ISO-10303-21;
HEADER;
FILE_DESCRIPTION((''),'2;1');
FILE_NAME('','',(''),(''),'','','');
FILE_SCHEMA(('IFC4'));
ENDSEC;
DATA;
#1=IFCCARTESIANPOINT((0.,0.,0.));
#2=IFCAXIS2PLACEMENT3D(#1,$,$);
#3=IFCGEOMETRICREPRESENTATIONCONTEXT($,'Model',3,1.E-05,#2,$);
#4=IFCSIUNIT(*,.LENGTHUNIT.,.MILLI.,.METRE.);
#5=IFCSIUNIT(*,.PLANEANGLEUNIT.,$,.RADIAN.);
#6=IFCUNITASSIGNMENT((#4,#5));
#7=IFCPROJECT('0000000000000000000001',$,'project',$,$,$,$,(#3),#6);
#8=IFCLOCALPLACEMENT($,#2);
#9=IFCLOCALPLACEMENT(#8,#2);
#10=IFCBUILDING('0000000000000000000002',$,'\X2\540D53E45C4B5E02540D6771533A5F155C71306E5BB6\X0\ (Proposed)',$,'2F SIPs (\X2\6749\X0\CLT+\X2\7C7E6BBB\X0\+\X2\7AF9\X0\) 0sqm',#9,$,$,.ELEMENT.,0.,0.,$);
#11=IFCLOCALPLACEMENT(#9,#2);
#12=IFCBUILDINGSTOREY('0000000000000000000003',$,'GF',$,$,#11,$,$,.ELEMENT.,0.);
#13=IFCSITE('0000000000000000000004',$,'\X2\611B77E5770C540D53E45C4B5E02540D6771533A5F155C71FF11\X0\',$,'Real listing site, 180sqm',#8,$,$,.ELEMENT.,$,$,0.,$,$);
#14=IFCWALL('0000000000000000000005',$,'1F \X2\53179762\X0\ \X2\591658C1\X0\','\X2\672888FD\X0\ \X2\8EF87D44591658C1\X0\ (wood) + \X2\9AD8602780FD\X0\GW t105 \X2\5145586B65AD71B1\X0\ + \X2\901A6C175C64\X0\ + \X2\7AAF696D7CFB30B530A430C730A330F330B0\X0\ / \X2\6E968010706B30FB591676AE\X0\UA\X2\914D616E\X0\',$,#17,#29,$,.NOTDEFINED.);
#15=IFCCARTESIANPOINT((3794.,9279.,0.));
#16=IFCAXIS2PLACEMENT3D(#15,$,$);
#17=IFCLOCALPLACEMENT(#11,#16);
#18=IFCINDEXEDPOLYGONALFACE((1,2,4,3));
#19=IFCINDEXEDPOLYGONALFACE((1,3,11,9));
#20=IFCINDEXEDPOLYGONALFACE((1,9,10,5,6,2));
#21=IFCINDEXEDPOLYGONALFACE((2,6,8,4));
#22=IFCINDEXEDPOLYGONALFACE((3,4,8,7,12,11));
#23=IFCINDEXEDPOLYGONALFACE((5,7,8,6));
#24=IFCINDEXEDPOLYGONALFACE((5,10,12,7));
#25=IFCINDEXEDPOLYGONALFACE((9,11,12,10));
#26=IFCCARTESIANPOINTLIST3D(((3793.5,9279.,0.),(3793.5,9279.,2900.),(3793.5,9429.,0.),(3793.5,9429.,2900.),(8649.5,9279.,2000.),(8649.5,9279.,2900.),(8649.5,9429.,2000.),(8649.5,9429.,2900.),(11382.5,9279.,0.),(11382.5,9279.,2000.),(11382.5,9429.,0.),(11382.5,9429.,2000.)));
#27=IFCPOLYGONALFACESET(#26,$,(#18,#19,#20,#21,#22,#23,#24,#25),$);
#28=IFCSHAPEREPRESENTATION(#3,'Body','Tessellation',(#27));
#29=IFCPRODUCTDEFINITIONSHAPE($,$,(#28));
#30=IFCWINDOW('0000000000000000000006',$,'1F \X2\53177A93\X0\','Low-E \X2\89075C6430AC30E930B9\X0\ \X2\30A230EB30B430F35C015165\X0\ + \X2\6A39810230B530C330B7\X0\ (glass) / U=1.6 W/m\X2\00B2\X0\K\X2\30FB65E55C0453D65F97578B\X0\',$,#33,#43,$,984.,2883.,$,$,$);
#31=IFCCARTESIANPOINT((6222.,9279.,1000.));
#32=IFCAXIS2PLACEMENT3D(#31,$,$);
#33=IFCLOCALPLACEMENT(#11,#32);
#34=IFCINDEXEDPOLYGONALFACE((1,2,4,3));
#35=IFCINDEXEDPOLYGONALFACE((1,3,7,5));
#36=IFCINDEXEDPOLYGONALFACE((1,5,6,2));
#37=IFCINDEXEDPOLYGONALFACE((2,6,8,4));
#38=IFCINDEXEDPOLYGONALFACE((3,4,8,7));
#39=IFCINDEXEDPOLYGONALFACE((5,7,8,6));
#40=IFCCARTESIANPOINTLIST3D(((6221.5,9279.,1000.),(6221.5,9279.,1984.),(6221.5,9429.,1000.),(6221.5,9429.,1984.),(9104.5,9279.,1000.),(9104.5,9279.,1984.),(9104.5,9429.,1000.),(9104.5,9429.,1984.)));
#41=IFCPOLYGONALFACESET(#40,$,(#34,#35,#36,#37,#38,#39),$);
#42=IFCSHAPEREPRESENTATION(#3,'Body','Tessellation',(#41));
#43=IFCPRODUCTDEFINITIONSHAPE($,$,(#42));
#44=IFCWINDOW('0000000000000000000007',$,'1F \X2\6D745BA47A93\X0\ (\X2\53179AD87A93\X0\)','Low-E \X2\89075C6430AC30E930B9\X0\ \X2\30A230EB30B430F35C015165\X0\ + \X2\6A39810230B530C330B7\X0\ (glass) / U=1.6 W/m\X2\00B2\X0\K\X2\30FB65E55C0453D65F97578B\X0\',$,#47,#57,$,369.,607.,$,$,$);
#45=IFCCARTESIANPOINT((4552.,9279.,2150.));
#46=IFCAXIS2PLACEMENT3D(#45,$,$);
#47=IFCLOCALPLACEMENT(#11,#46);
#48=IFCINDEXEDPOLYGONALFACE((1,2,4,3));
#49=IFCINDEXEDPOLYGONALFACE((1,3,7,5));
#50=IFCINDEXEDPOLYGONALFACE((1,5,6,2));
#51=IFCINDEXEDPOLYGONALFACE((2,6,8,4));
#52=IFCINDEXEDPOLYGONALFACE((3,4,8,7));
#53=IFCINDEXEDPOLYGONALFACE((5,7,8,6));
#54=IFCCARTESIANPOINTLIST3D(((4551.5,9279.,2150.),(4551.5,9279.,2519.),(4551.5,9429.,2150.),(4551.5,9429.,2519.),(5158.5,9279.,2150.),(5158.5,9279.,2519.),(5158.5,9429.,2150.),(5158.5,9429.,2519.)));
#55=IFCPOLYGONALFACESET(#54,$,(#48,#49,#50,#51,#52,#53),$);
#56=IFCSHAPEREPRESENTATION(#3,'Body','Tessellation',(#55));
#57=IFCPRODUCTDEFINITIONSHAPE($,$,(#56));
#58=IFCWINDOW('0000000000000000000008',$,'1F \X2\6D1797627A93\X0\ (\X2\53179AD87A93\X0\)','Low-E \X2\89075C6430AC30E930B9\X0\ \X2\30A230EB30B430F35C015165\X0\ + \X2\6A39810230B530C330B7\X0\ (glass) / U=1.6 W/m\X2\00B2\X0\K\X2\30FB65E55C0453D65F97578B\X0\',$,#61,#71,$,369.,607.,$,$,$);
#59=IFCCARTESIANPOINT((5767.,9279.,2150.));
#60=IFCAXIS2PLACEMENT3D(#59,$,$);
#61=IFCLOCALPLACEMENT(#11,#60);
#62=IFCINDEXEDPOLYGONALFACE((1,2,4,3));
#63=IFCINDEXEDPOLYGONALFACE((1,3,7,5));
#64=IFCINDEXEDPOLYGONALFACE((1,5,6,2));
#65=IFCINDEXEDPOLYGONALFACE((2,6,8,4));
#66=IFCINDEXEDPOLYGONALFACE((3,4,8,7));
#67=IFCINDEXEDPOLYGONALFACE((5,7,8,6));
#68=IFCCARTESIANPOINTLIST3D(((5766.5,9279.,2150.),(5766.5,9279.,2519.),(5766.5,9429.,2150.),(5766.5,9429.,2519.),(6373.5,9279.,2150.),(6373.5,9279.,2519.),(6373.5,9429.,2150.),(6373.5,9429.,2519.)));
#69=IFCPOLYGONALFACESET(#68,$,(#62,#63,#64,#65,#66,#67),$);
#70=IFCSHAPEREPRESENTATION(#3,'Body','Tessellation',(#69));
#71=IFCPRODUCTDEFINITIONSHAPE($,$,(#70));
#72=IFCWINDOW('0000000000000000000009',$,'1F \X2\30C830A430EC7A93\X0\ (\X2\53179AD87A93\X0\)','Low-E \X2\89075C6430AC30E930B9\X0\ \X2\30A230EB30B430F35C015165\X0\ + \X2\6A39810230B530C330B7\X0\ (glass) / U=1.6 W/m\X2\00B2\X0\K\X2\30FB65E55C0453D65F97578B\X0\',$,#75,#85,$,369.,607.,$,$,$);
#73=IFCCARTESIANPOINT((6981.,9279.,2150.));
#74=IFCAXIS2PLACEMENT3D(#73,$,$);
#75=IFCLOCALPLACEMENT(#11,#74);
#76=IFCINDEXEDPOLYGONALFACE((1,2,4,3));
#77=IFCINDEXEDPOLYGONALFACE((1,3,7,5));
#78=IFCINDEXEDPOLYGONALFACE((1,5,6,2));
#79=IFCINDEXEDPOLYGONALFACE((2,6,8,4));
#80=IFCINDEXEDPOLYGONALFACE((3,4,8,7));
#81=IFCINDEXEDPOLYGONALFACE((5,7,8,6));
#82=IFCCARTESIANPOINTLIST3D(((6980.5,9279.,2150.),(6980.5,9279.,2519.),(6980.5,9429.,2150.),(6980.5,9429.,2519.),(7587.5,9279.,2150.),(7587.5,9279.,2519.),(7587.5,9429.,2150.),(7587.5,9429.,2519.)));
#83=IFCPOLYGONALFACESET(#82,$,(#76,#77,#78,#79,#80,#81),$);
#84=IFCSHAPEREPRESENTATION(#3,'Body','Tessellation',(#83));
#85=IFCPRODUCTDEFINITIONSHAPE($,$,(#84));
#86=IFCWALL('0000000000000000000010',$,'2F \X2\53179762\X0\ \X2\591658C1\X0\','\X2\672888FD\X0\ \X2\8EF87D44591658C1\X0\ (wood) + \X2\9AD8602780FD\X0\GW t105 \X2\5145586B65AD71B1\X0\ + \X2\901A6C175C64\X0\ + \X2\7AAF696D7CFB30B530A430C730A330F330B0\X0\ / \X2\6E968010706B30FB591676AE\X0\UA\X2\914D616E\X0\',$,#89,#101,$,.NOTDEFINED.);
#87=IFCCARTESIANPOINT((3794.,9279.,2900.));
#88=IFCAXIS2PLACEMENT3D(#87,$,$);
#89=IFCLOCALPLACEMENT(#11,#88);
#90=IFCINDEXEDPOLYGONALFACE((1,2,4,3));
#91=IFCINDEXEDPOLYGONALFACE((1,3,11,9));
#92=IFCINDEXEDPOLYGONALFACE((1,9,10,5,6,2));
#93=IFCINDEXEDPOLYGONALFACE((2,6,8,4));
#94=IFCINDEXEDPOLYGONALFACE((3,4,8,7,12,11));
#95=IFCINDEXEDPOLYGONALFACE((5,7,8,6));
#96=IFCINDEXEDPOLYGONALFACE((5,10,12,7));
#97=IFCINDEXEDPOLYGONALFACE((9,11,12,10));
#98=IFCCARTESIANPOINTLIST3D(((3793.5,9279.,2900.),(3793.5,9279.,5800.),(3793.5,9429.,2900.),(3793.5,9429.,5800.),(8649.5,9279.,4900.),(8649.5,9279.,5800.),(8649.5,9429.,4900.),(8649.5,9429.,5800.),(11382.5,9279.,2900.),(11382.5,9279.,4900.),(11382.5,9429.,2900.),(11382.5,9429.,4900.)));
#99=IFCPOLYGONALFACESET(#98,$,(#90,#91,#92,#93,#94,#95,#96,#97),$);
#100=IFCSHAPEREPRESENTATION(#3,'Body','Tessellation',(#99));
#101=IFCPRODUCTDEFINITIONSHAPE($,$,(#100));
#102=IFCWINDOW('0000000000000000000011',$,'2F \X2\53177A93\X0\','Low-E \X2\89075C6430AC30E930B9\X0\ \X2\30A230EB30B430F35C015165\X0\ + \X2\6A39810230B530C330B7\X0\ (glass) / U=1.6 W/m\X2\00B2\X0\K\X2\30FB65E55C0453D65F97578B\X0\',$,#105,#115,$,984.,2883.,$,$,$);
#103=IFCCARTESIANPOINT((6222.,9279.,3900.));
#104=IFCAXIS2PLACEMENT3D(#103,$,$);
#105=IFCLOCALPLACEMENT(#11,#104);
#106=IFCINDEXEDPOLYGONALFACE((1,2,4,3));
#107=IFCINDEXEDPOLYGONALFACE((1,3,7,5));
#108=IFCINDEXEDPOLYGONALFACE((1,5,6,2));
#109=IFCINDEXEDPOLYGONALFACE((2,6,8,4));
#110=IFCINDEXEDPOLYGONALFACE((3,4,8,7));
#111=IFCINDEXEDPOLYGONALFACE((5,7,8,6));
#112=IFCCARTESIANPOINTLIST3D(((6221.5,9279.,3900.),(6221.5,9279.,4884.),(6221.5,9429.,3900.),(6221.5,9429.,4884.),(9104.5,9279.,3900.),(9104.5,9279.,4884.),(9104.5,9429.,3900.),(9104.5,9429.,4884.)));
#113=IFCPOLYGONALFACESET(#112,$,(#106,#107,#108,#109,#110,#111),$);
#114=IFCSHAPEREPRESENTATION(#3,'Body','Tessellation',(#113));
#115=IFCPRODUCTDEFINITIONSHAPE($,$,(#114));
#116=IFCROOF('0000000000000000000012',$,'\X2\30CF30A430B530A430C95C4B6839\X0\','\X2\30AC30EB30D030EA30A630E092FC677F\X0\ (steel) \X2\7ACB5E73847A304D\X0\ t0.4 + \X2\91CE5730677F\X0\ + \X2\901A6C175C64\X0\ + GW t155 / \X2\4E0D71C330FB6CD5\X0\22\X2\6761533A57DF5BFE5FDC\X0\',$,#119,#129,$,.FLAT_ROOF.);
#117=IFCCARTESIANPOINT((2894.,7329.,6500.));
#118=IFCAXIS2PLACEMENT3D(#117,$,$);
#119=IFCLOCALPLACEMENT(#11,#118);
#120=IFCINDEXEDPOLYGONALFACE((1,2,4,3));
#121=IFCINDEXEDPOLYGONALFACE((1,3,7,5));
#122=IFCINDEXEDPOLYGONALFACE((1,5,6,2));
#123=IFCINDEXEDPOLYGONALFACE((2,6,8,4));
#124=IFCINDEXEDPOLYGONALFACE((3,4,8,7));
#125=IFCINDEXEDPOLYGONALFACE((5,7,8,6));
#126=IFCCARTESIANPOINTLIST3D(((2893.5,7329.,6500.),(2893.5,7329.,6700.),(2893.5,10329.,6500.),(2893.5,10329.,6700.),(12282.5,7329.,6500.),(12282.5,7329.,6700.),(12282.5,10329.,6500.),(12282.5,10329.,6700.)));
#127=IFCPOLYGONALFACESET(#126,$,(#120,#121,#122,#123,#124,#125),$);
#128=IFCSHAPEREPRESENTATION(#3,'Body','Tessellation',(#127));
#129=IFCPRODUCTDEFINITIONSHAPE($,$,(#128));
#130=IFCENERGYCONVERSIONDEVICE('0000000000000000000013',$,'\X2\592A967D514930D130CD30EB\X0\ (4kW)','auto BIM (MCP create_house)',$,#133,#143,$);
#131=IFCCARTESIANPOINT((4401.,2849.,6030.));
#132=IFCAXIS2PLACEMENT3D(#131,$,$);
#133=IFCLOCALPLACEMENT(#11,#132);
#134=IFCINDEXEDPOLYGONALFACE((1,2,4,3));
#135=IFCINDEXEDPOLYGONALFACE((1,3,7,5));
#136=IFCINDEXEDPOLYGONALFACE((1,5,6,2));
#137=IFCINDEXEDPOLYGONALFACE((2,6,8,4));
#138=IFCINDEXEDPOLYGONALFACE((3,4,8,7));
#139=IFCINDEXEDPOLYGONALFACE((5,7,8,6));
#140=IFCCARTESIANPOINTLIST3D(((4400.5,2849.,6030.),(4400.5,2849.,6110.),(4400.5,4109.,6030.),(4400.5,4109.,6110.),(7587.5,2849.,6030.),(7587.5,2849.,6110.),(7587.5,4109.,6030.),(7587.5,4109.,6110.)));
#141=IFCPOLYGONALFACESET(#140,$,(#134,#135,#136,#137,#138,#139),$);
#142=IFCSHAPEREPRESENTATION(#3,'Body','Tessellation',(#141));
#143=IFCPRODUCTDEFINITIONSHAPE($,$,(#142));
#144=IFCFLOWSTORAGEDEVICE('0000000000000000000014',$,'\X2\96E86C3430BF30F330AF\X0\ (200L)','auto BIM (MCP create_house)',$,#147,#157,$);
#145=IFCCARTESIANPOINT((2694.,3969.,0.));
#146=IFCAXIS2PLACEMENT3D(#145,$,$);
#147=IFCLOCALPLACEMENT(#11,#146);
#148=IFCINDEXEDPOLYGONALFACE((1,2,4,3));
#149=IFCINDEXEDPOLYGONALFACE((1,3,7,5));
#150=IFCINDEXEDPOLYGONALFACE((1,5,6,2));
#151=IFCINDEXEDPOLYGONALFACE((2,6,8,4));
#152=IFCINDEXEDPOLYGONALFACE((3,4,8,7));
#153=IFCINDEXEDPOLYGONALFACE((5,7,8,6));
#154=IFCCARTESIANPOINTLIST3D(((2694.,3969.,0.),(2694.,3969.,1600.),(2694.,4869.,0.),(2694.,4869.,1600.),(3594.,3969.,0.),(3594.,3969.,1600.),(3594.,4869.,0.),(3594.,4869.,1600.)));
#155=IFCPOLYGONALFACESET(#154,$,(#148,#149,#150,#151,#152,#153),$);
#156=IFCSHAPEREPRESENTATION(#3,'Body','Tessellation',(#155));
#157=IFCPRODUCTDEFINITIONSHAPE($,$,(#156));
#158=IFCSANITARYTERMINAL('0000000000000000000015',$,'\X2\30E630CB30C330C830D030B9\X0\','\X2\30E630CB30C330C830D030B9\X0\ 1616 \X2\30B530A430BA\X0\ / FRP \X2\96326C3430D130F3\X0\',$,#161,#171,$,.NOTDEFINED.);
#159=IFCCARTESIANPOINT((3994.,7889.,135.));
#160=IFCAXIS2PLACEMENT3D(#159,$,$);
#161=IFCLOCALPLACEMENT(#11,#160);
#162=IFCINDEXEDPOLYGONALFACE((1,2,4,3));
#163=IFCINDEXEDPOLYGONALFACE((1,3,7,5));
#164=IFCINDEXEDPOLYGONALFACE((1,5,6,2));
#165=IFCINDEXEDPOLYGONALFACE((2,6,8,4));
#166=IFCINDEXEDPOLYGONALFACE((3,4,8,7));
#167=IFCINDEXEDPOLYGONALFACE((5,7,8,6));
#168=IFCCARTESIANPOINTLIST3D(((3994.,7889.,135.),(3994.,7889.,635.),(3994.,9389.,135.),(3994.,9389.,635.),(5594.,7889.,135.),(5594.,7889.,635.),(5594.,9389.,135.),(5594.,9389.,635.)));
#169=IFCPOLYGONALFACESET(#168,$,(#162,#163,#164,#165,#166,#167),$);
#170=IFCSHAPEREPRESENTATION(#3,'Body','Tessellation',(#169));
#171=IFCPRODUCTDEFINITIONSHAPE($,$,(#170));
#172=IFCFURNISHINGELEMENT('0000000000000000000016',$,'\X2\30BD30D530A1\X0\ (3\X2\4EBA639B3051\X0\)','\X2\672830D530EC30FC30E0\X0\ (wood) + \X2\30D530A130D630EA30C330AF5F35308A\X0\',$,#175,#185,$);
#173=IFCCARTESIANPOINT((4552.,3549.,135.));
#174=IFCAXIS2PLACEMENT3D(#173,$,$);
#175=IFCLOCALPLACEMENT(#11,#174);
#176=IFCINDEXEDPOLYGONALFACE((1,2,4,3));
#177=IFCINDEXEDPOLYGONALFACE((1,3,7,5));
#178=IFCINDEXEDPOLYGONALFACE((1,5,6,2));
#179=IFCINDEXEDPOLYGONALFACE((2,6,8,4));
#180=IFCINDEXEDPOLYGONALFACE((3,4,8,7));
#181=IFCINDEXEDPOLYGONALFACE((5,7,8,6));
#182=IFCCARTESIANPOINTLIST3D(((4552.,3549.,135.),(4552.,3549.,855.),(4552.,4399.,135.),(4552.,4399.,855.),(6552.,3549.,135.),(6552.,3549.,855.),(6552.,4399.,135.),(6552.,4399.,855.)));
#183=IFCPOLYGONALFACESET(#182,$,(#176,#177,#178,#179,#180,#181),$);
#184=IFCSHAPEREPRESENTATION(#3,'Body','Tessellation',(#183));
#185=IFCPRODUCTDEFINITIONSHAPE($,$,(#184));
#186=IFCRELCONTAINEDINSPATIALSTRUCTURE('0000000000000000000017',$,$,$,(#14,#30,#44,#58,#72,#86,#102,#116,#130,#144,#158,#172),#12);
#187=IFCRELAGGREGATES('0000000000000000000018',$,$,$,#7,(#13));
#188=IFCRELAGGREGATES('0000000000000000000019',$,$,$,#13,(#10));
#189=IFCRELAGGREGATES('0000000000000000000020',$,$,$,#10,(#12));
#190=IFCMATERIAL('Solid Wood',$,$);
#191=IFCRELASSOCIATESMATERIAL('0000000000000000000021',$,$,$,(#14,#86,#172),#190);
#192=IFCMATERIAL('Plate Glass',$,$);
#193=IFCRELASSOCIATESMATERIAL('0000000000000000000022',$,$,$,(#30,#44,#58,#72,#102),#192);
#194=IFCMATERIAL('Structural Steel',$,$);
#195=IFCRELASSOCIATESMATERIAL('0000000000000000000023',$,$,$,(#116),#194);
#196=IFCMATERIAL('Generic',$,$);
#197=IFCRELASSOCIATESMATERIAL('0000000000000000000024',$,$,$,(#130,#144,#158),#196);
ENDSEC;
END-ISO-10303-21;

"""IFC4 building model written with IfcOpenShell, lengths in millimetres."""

from ifc_helpers import new_model, si_unit, frame, frame_2d, origin, place, context, project, spatial, rectangle, extrude, material, element, fill, save


model = new_model("IFC4")

# Units and contexts
model_context = context("Model", 3, precision=1e-05, world=origin())
ifc_project = project(units=[si_unit("LENGTHUNIT", "METRE", prefix="MILLI"), si_unit("PLANEANGLEUNIT", "RADIAN")], contexts=[model_context])

# Site, building, storey
site_placement = place(None, origin())
site = spatial("IfcSite", under=ifc_project, at=site_placement, Name="愛知県名古屋市名東区引山１", ObjectType="Real listing site, 180sqm", CompositionType="ELEMENT", RefElevation=0.0)
building_placement = place(site_placement, origin())
building = spatial("IfcBuilding", under=site, at=building_placement, Name="名古屋市名東区引山の家 (Proposed)", ObjectType="2F SIPs (杉CLT+籾殻+竹) 0sqm", CompositionType="ELEMENT", ElevationOfRefHeight=0.0, ElevationOfTerrain=0.0)
storey_placement = place(building_placement, origin())
storey = spatial("IfcBuildingStorey", under=building, at=storey_placement, Name="GF", CompositionType="ELEMENT", Elevation=0.0)

# Wall, openings, windows
ifc_material_1 = material(Name="Solid Wood")
wall_1_placement = place(storey_placement, frame((3794.0, 9279.0, 0.0)))
wall_1 = element("IfcWall", 1, at=wall_1_placement, inside=storey, material=ifc_material_1, Name="1F 北面 外壁", Description="木製 軸組外壁 (wood) + 高性能GW t105 充填断熱 + 通気層 + 窯業系サイディング / 準耐火・外皮UA配慮", PredefinedType="NOTDEFINED", context=model_context, shape_type="SweptSolid", body=[
    extrude(rectangle(XDim=7589.0, YDim=150.0, at=frame_2d((3794.0, 75.0))), frame((3794.0, 9279.0, 0.0)), (0.0, 0.0, 1.0), 2900.0),
])
opening_1_placement = place(storey_placement, frame((6222.0, 9279.0, 1000.0)))
opening_1 = element("IfcOpeningElement", 2, at=opening_1_placement, cuts=wall_1, PredefinedType="NOTDEFINED", context=model_context, shape_type="SweptSolid", body=[
    extrude(rectangle(XDim=2883.0, YDim=150.0, at=frame_2d((1441.0, 75.0))), frame((6222.0, 9279.0, 1000.0)), (0.0, 0.0, 1.0), 984.0),
])
opening_2_placement = place(storey_placement, frame((4552.0, 9279.0, 2150.0)))
opening_2 = element("IfcOpeningElement", 3, at=opening_2_placement, cuts=wall_1, PredefinedType="NOTDEFINED", context=model_context, shape_type="SweptSolid", body=[
    extrude(rectangle(XDim=607.0, YDim=150.0, at=frame_2d((303.0, 75.0))), frame((4552.0, 9279.0, 2150.0)), (0.0, 0.0, 1.0), 369.0),
])
opening_3_placement = place(storey_placement, frame((5767.0, 9279.0, 2150.0)))
opening_3 = element("IfcOpeningElement", 4, at=opening_3_placement, cuts=wall_1, PredefinedType="NOTDEFINED", context=model_context, shape_type="SweptSolid", body=[
    extrude(rectangle(XDim=607.0, YDim=150.0, at=frame_2d((303.0, 75.0))), frame((5767.0, 9279.0, 2150.0)), (0.0, 0.0, 1.0), 369.0),
])
opening_4_placement = place(storey_placement, frame((6981.0, 9279.0, 2150.0)))
opening_4 = element("IfcOpeningElement", 5, at=opening_4_placement, cuts=wall_1, PredefinedType="NOTDEFINED", context=model_context, shape_type="SweptSolid", body=[
    extrude(rectangle(XDim=607.0, YDim=150.0, at=frame_2d((303.0, 75.0))), frame((6981.0, 9279.0, 2150.0)), (0.0, 0.0, 1.0), 369.0),
])
ifc_material_2 = material(Name="Plate Glass")
window_1_placement = place(storey_placement, frame((6222.0, 9279.0, 1000.0)))
window_1 = element("IfcWindow", 6, at=window_1_placement, inside=storey, material=ifc_material_2, Name="1F 北窓", Description="Low-E 複層ガラス アルゴン封入 + 樹脂サッシ (glass) / U=1.6 W/m²K・日射取得型", OverallHeight=984.0, OverallWidth=2883.0, context=model_context, shape_type="SweptSolid", body=[
    extrude(rectangle(XDim=2883.0, YDim=150.0, at=frame_2d((1441.0, 75.0))), frame((6222.0, 9279.0, 1000.0)), (0.0, 0.0, 1.0), 984.0),
])
fill(opening_1, window_1)
window_2_placement = place(storey_placement, frame((4552.0, 9279.0, 2150.0)))
window_2 = element("IfcWindow", 7, at=window_2_placement, inside=storey, material=ifc_material_2, Name="1F 浴室窓 (北高窓)", Description="Low-E 複層ガラス アルゴン封入 + 樹脂サッシ (glass) / U=1.6 W/m²K・日射取得型", OverallHeight=369.0, OverallWidth=607.0, context=model_context, shape_type="SweptSolid", body=[
    extrude(rectangle(XDim=607.0, YDim=150.0, at=frame_2d((303.0, 75.0))), frame((4552.0, 9279.0, 2150.0)), (0.0, 0.0, 1.0), 369.0),
])
fill(opening_2, window_2)
window_3_placement = place(storey_placement, frame((5767.0, 9279.0, 2150.0)))
window_3 = element("IfcWindow", 8, at=window_3_placement, inside=storey, material=ifc_material_2, Name="1F 洗面窓 (北高窓)", Description="Low-E 複層ガラス アルゴン封入 + 樹脂サッシ (glass) / U=1.6 W/m²K・日射取得型", OverallHeight=369.0, OverallWidth=607.0, context=model_context, shape_type="SweptSolid", body=[
    extrude(rectangle(XDim=607.0, YDim=150.0, at=frame_2d((303.0, 75.0))), frame((5767.0, 9279.0, 2150.0)), (0.0, 0.0, 1.0), 369.0),
])
fill(opening_3, window_3)
window_4_placement = place(storey_placement, frame((6981.0, 9279.0, 2150.0)))
window_4 = element("IfcWindow", 9, at=window_4_placement, inside=storey, material=ifc_material_2, Name="1F トイレ窓 (北高窓)", Description="Low-E 複層ガラス アルゴン封入 + 樹脂サッシ (glass) / U=1.6 W/m²K・日射取得型", OverallHeight=369.0, OverallWidth=607.0, context=model_context, shape_type="SweptSolid", body=[
    extrude(rectangle(XDim=607.0, YDim=150.0, at=frame_2d((303.0, 75.0))), frame((6981.0, 9279.0, 2150.0)), (0.0, 0.0, 1.0), 369.0),
])
fill(opening_4, window_4)

# Wall, opening, window
wall_2_placement = place(storey_placement, frame((3794.0, 9279.0, 2900.0)))
wall_2 = element("IfcWall", 10, at=wall_2_placement, inside=storey, material=ifc_material_1, Name="2F 北面 外壁", Description="木製 軸組外壁 (wood) + 高性能GW t105 充填断熱 + 通気層 + 窯業系サイディング / 準耐火・外皮UA配慮", PredefinedType="NOTDEFINED", context=model_context, shape_type="SweptSolid", body=[
    extrude(rectangle(XDim=7589.0, YDim=150.0, at=frame_2d((3794.0, 75.0))), frame((3794.0, 9279.0, 2900.0)), (0.0, 0.0, 1.0), 2900.0),
])
opening_5_placement = place(storey_placement, frame((6222.0, 9279.0, 3900.0)))
opening_5 = element("IfcOpeningElement", 11, at=opening_5_placement, cuts=wall_2, PredefinedType="NOTDEFINED", context=model_context, shape_type="SweptSolid", body=[
    extrude(rectangle(XDim=2883.0, YDim=150.0, at=frame_2d((1441.0, 75.0))), frame((6222.0, 9279.0, 3900.0)), (0.0, 0.0, 1.0), 984.0),
])
window_5_placement = place(storey_placement, frame((6222.0, 9279.0, 3900.0)))
window_5 = element("IfcWindow", 12, at=window_5_placement, inside=storey, material=ifc_material_2, Name="2F 北窓", Description="Low-E 複層ガラス アルゴン封入 + 樹脂サッシ (glass) / U=1.6 W/m²K・日射取得型", OverallHeight=984.0, OverallWidth=2883.0, context=model_context, shape_type="SweptSolid", body=[
    extrude(rectangle(XDim=2883.0, YDim=150.0, at=frame_2d((1441.0, 75.0))), frame((6222.0, 9279.0, 3900.0)), (0.0, 0.0, 1.0), 984.0),
])
fill(opening_5, window_5)

# Roof
ifc_material_3 = material(Name="Structural Steel")
roof_placement = place(storey_placement, frame((2894.0, 7329.0, 6500.0)))
element("IfcRoof", 13, at=roof_placement, inside=storey, material=ifc_material_3, Name="ハイサイド屋根", Description="ガルバリウム鋼板 (steel) 立平葺き t0.4 + 野地板 + 通気層 + GW t155 / 不燃・法22条区域対応", PredefinedType="FLAT_ROOF", context=model_context, shape_type="SweptSolid", body=[
    extrude(rectangle(XDim=9389.0, YDim=3000.0, at=frame_2d((4694.0, 1500.0))), frame((2894.0, 7329.0, 6500.0)), (0.0, 0.0, 1.0), 200.0),
])

# Energy conversion device
ifc_material_4 = material(Name="Generic")
energy_conversion_device_placement = place(storey_placement, frame((4401.0, 2849.0, 6030.0)))
element("IfcEnergyConversionDevice", 14, at=energy_conversion_device_placement, inside=storey, material=ifc_material_4, Name="太陽光パネル (4kW)", Description="auto BIM (MCP create_house)", context=model_context, shape_type="SweptSolid", body=[
    extrude(rectangle(XDim=3187.0, YDim=1260.0, at=frame_2d((1593.0, 630.0))), frame((4401.0, 2849.0, 6030.0)), (0.0, 0.0, 1.0), 80.0),
])

# Flow storage device
flow_storage_device_placement = place(storey_placement, frame((2694.0, 3969.0, 0.0)))
element("IfcFlowStorageDevice", 15, at=flow_storage_device_placement, inside=storey, material=ifc_material_4, Name="雨水タンク (200L)", Description="auto BIM (MCP create_house)", context=model_context, shape_type="SweptSolid", body=[
    extrude(rectangle(XDim=900.0, YDim=900.0, at=frame_2d((450.0, 450.0))), frame((2694.0, 3969.0, 0.0)), (0.0, 0.0, 1.0), 1600.0),
])

# Sanitary terminal
sanitary_terminal_placement = place(storey_placement, frame((3994.0, 7889.0, 135.0)))
element("IfcSanitaryTerminal", 16, at=sanitary_terminal_placement, inside=storey, material=ifc_material_4, Name="ユニットバス", Description="ユニットバス 1616 サイズ / FRP 防水パン", PredefinedType="NOTDEFINED", context=model_context, shape_type="SweptSolid", body=[
    extrude(rectangle(XDim=1600.0, YDim=1500.0, at=frame_2d((800.0, 750.0))), frame((3994.0, 7889.0, 135.0)), (0.0, 0.0, 1.0), 500.0),
])

# Furnishing element
furnishing_1_placement = place(storey_placement, frame((4552.0, 3549.0, 135.0)))
element("IfcFurnishingElement", 17, at=furnishing_1_placement, inside=storey, material=ifc_material_1, Name="ソファ (3人掛け)", Description="木フレーム (wood) + ファブリック張り", context=model_context, shape_type="SweptSolid", body=[
    extrude(rectangle(XDim=2000.0, YDim=850.0, at=frame_2d((1000.0, 425.0))), frame((4552.0, 3549.0, 135.0)), (0.0, 0.0, 1.0), 720.0),
])

save(model, "model.ifc")
